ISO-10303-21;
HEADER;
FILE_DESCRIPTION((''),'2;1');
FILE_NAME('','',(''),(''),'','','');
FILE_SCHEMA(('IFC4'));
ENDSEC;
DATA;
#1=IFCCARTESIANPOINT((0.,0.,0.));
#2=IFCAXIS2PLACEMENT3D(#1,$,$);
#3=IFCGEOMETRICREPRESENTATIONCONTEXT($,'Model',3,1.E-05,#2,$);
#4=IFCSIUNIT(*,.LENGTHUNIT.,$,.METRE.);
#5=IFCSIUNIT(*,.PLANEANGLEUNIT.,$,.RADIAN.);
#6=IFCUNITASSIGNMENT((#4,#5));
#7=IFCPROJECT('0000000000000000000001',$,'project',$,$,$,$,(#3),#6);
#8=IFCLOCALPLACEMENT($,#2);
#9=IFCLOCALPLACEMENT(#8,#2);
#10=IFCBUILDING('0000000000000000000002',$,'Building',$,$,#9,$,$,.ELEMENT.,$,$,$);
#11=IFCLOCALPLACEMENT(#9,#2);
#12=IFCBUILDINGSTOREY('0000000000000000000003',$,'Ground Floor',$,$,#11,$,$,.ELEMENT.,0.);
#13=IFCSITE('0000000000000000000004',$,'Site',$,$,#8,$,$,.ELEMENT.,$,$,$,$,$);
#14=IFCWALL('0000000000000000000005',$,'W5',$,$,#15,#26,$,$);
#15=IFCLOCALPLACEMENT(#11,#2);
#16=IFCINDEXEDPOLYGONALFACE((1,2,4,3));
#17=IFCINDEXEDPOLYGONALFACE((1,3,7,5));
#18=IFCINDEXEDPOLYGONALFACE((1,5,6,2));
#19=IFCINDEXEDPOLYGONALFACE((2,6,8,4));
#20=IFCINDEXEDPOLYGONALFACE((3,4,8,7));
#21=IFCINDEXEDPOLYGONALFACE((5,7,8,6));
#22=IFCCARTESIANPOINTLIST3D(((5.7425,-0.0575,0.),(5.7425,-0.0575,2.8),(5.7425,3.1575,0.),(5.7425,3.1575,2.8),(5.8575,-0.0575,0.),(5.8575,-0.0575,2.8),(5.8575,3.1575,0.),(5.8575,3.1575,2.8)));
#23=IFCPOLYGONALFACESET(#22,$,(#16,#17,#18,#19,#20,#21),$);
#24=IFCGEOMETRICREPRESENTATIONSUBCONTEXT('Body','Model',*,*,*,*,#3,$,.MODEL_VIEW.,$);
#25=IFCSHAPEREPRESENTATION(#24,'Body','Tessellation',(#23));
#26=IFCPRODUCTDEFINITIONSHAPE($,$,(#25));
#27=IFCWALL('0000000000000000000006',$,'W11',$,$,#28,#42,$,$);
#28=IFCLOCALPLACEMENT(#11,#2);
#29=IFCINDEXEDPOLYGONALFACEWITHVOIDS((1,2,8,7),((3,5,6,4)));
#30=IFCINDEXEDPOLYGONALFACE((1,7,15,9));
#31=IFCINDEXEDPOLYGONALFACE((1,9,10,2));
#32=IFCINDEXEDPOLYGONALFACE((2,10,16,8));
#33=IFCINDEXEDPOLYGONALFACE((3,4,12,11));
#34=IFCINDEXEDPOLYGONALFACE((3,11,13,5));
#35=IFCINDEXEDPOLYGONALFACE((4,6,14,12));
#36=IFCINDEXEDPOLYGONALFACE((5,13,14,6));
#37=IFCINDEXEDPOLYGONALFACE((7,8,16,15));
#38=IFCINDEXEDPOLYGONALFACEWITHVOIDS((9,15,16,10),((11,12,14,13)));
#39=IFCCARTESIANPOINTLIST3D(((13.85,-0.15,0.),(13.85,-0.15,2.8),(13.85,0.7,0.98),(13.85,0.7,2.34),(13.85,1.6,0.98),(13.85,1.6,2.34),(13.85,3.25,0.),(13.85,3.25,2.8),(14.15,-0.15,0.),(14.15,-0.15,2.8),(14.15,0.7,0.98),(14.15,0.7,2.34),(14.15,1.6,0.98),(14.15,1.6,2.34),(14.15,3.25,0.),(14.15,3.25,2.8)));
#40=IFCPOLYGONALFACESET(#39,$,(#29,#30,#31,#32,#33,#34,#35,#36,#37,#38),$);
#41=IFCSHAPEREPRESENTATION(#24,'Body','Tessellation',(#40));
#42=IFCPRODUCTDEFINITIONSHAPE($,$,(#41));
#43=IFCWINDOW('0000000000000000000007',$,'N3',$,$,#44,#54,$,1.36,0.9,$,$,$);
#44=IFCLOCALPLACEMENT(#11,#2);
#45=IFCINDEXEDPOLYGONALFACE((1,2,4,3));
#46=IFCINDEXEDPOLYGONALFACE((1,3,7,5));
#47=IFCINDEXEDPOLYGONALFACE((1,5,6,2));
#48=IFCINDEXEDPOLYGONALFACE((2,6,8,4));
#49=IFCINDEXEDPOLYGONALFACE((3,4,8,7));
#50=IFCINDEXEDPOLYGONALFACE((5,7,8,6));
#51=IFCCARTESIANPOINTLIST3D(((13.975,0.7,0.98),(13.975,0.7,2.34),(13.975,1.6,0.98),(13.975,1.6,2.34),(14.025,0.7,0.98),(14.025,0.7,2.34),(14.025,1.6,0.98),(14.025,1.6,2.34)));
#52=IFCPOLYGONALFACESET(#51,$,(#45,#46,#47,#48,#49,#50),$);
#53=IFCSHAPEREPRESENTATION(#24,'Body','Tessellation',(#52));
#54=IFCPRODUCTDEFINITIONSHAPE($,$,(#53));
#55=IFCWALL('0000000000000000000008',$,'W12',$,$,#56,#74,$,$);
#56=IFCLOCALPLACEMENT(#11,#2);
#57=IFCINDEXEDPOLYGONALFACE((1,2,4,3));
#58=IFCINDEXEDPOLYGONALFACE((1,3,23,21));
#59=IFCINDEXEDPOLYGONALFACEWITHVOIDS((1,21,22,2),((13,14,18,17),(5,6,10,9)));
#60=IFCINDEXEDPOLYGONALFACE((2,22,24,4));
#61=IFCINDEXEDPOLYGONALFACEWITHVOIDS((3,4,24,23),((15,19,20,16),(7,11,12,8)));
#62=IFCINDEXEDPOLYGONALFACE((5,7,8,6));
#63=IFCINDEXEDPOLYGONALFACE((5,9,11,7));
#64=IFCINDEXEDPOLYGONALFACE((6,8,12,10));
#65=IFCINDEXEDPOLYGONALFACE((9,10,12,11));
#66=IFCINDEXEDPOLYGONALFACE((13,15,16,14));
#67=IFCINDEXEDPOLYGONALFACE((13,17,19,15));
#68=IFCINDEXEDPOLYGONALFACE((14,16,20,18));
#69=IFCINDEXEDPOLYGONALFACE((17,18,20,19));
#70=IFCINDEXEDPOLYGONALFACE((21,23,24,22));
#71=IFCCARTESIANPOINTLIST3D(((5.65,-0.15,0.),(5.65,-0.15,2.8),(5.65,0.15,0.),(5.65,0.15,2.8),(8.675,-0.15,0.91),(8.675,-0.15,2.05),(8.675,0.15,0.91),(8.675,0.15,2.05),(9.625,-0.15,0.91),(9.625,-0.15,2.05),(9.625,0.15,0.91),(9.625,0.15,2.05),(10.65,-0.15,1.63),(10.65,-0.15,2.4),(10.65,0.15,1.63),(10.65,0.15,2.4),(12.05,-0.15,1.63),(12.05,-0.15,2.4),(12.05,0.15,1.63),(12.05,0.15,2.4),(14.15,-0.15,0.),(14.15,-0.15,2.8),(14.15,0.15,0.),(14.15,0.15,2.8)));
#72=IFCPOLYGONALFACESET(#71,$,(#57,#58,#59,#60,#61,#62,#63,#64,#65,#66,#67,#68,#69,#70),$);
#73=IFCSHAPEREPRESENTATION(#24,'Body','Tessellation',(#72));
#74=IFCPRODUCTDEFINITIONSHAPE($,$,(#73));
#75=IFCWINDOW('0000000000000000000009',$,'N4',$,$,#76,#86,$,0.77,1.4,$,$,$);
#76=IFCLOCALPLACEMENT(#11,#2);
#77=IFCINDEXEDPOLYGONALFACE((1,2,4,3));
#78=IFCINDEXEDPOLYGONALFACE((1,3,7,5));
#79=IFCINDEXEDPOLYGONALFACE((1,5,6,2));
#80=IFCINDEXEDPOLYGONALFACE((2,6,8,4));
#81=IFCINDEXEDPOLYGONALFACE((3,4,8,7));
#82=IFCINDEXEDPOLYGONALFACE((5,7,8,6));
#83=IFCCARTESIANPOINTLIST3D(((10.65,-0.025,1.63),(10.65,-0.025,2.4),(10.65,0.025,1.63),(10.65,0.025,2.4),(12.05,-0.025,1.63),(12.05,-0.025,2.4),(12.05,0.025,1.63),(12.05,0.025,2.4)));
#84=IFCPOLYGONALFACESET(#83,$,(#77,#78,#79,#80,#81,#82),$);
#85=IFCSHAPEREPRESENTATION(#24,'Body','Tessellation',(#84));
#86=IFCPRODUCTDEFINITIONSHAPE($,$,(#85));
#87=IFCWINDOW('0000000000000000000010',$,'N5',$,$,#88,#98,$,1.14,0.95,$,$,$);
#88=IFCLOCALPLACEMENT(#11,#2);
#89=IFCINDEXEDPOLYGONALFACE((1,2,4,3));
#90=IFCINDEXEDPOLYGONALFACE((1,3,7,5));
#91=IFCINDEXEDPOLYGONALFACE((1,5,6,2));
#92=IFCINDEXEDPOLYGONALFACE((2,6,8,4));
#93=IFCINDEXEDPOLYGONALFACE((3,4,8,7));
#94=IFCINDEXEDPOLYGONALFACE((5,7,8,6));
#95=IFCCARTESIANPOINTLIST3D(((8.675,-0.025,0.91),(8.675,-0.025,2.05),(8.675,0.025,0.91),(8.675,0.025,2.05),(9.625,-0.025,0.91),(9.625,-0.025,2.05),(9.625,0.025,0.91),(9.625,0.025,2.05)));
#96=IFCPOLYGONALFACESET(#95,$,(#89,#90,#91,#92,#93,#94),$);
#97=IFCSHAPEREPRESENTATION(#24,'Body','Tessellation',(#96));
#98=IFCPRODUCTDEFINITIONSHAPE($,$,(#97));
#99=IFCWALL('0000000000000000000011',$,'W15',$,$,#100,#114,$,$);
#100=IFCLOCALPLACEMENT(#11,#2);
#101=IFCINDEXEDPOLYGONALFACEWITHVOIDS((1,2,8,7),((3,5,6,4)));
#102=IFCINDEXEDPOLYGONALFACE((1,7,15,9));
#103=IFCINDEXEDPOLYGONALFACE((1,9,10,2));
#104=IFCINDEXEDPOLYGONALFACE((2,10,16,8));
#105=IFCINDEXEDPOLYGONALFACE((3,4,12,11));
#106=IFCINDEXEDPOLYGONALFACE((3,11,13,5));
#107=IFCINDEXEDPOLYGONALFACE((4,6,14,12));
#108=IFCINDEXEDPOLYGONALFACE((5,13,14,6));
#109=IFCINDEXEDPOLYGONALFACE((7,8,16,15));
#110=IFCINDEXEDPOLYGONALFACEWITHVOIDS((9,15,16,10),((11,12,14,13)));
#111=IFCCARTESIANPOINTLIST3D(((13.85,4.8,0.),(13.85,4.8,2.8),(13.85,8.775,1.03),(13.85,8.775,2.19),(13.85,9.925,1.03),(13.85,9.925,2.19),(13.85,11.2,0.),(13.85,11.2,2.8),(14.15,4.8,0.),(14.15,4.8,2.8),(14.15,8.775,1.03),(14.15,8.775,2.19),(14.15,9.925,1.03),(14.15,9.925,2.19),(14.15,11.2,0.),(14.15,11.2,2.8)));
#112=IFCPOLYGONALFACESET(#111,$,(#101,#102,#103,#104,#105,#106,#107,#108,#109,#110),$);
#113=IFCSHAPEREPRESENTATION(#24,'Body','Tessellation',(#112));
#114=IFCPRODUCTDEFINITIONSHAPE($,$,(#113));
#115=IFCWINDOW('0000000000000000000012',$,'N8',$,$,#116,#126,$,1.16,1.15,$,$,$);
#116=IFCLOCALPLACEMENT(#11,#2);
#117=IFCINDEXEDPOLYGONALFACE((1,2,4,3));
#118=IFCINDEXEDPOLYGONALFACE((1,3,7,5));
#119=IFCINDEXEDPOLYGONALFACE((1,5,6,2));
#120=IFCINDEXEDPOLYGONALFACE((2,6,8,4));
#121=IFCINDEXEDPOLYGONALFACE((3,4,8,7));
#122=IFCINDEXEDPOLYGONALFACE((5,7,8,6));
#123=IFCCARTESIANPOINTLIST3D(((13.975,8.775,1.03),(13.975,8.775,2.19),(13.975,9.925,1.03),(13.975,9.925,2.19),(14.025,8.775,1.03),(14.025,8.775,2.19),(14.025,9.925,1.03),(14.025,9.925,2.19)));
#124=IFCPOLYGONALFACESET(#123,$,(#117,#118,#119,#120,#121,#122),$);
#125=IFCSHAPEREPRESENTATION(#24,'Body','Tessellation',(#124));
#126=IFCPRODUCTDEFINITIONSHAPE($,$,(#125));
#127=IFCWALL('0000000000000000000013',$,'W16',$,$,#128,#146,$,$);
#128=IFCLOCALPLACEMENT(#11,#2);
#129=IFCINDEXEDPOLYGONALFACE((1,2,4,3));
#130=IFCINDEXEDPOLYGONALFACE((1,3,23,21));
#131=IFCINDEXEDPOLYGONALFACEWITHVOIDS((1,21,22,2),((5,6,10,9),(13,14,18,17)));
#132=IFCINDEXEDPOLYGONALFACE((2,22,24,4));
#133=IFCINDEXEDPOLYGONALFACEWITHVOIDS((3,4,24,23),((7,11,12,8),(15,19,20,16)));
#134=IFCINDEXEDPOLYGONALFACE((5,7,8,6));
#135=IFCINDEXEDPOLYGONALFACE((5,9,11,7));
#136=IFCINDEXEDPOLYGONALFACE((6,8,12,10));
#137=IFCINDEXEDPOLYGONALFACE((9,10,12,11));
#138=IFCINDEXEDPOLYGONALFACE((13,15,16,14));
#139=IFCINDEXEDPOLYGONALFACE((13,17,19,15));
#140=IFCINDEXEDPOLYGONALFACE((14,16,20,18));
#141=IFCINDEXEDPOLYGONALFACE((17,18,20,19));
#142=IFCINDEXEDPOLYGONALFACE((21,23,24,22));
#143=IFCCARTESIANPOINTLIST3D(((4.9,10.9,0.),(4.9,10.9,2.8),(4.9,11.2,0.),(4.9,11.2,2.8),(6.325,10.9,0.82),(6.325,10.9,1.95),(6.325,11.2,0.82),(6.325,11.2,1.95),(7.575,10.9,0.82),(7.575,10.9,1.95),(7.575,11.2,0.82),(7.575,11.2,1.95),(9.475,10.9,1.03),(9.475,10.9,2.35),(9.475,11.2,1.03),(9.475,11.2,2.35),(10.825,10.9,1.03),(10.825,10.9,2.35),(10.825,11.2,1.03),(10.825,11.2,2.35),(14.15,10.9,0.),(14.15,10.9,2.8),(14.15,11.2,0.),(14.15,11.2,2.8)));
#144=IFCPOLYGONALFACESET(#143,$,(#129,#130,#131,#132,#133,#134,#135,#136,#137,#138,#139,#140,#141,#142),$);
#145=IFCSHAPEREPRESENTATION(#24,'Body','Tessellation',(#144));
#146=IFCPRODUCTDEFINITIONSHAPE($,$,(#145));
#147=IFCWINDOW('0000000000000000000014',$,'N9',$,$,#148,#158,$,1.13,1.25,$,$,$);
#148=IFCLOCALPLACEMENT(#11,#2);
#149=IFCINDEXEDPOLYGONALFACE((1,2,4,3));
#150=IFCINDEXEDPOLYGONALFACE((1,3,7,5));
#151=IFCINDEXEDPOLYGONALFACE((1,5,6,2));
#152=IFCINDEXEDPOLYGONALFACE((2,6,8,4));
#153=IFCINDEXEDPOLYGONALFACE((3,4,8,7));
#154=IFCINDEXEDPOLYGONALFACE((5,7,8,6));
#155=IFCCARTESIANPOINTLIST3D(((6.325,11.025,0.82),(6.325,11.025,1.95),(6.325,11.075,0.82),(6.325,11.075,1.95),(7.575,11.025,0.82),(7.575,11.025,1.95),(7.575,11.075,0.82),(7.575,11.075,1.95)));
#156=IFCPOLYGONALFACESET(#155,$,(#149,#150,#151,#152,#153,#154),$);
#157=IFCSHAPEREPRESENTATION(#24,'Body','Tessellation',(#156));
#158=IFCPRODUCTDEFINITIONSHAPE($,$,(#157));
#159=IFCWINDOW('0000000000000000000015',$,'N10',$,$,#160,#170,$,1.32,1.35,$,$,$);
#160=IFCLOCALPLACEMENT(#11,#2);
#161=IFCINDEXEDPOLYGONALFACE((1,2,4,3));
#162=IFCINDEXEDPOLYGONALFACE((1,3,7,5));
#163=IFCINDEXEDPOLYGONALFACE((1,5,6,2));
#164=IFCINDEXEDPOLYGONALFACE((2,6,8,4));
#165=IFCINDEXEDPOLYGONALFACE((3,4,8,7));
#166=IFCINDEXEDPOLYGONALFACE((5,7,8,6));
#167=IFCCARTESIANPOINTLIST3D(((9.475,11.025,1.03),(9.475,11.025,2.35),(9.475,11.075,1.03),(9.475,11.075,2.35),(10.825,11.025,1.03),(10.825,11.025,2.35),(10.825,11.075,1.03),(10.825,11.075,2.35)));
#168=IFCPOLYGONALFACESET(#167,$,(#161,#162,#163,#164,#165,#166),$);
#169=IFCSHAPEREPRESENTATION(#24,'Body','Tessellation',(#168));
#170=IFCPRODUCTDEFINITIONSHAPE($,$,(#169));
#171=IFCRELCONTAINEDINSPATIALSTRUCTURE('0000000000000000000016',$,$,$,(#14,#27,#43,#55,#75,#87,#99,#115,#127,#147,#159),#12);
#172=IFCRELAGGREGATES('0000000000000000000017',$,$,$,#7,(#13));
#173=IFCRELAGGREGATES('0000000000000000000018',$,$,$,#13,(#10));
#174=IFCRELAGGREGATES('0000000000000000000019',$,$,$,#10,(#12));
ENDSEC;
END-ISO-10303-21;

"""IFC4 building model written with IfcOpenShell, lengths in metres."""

from ifc_helpers import new_model, si_unit, frame, frame_2d, origin, origin_2d, place, context, subcontext, project, spatial, rectangle, extrude, element, fill, save


model = new_model("IFC4")

# Units and contexts
model_context = context("Model", 3, precision=1e-05, world=origin())
body_context = subcontext(model_context, "Body", "Model", "MODEL_VIEW")
ifc_project = project(units=[si_unit("LENGTHUNIT", "METRE"), si_unit("PLANEANGLEUNIT", "RADIAN")], contexts=[model_context])

# Site, building, storey
site_placement = place(None, origin())
site = spatial("IfcSite", under=ifc_project, at=site_placement, Name="Site", CompositionType="ELEMENT")
building_placement = place(site_placement, origin())
building = spatial("IfcBuilding", under=site, at=building_placement, Name="Building", CompositionType="ELEMENT")
storey_placement = place(building_placement, origin())
storey = spatial("IfcBuildingStorey", under=building, at=storey_placement, Name="Ground Floor", CompositionType="ELEMENT", Elevation=0.0)

# Wall
wall_1_placement = place(storey_placement, frame((5.8, 0.0, 0.0), x_axis=(0.0, 1.0, 0.0)))
element("IfcWall", 1, at=wall_1_placement, inside=storey, Name="W5", context=body_context, shape_type="SweptSolid", body=[
    extrude(rectangle(XDim=3.215, YDim=0.115, at=frame_2d((1.55, 0.0))), origin(), (0.0, 0.0, 1.0), 2.8),
])

# Wall, opening, window
wall_2_placement = place(storey_placement, frame((14.0, 0.0, 0.0), x_axis=(0.0, 1.0, 0.0)))
wall_2 = element("IfcWall", 2, at=wall_2_placement, inside=storey, Name="W11", context=body_context, shape_type="SweptSolid", body=[
    extrude(rectangle(XDim=3.4, YDim=0.3, at=frame_2d((1.55, 0.0))), origin(), (0.0, 0.0, 1.0), 2.8),
])
opening_1_placement = place(wall_2_placement, frame((1.15, 0.0, 0.98)))
opening_1 = element("IfcOpeningElement", 3, at=opening_1_placement, cuts=wall_2, context=body_context, shape_type="SweptSolid", body=[
    extrude(rectangle(XDim=0.9, YDim=0.4, at=origin_2d()), origin(), (0.0, 0.0, 1.0), 1.36),
])
window_1_placement = place(opening_1_placement, origin())
window_1 = element("IfcWindow", 4, at=window_1_placement, inside=storey, Name="N3", OverallHeight=1.36, OverallWidth=0.9, context=body_context, shape_type="SweptSolid", body=[
    extrude(rectangle(XDim=0.9, YDim=0.05, at=origin_2d()), origin(), (0.0, 0.0, 1.0), 1.36),
])
fill(opening_1, window_1)

# Wall, openings, windows
wall_3_placement = place(storey_placement, frame((5.8, 0.0, 0.0), x_axis=(1.0, 0.0, 0.0)))
wall_3 = element("IfcWall", 5, at=wall_3_placement, inside=storey, Name="W12", context=body_context, shape_type="SweptSolid", body=[
    extrude(rectangle(XDim=8.5, YDim=0.3, at=frame_2d((4.1, 0.0))), origin(), (0.0, 0.0, 1.0), 2.8),
])
opening_2_placement = place(wall_3_placement, frame((5.55, 0.0, 1.63)))
opening_2 = element("IfcOpeningElement", 6, at=opening_2_placement, cuts=wall_3, context=body_context, shape_type="SweptSolid", body=[
    extrude(rectangle(XDim=1.4, YDim=0.4, at=origin_2d()), origin(), (0.0, 0.0, 1.0), 0.77),
])
opening_3_placement = place(wall_3_placement, frame((3.35, 0.0, 0.91)))
opening_3 = element("IfcOpeningElement", 7, at=opening_3_placement, cuts=wall_3, context=body_context, shape_type="SweptSolid", body=[
    extrude(rectangle(XDim=0.95, YDim=0.4, at=origin_2d()), origin(), (0.0, 0.0, 1.0), 1.14),
])
window_2_placement = place(opening_2_placement, origin())
window_2 = element("IfcWindow", 8, at=window_2_placement, inside=storey, Name="N4", OverallHeight=0.77, OverallWidth=1.4, context=body_context, shape_type="SweptSolid", body=[
    extrude(rectangle(XDim=1.4, YDim=0.05, at=origin_2d()), origin(), (0.0, 0.0, 1.0), 0.77),
])
fill(opening_2, window_2)
window_3_placement = place(opening_3_placement, origin())
window_3 = element("IfcWindow", 9, at=window_3_placement, inside=storey, Name="N5", OverallHeight=1.14, OverallWidth=0.95, context=body_context, shape_type="SweptSolid", body=[
    extrude(rectangle(XDim=0.95, YDim=0.05, at=origin_2d()), origin(), (0.0, 0.0, 1.0), 1.14),
])
fill(opening_3, window_3)

# Wall, opening, window
wall_4_placement = place(storey_placement, frame((14.0, 4.95, 0.0), x_axis=(0.0, 1.0, 0.0)))
wall_4 = element("IfcWall", 10, at=wall_4_placement, inside=storey, Name="W15", context=body_context, shape_type="SweptSolid", body=[
    extrude(rectangle(XDim=6.4, YDim=0.3, at=frame_2d((3.05, 0.0))), origin(), (0.0, 0.0, 1.0), 2.8),
])
opening_4_placement = place(wall_4_placement, frame((4.4, 0.0, 1.03)))
opening_4 = element("IfcOpeningElement", 11, at=opening_4_placement, cuts=wall_4, context=body_context, shape_type="SweptSolid", body=[
    extrude(rectangle(XDim=1.15, YDim=0.4, at=origin_2d()), origin(), (0.0, 0.0, 1.0), 1.16),
])
window_4_placement = place(opening_4_placement, origin())
window_4 = element("IfcWindow", 12, at=window_4_placement, inside=storey, Name="N8", OverallHeight=1.16, OverallWidth=1.15, context=body_context, shape_type="SweptSolid", body=[
    extrude(rectangle(XDim=1.15, YDim=0.05, at=origin_2d()), origin(), (0.0, 0.0, 1.0), 1.16),
])
fill(opening_4, window_4)

# Wall, openings, windows
wall_5_placement = place(storey_placement, frame((5.05, 11.05, 0.0), x_axis=(1.0, 0.0, 0.0)))
wall_5 = element("IfcWall", 13, at=wall_5_placement, inside=storey, Name="W16", context=body_context, shape_type="SweptSolid", body=[
    extrude(rectangle(XDim=9.25, YDim=0.3, at=frame_2d((4.475, 0.0))), origin(), (0.0, 0.0, 1.0), 2.8),
])
opening_5_placement = place(wall_5_placement, frame((1.9, 0.0, 0.82)))
opening_5 = element("IfcOpeningElement", 14, at=opening_5_placement, cuts=wall_5, context=body_context, shape_type="SweptSolid", body=[
    extrude(rectangle(XDim=1.25, YDim=0.4, at=origin_2d()), origin(), (0.0, 0.0, 1.0), 1.13),
])
opening_6_placement = place(wall_5_placement, frame((5.1, 0.0, 1.03)))
opening_6 = element("IfcOpeningElement", 15, at=opening_6_placement, cuts=wall_5, context=body_context, shape_type="SweptSolid", body=[
    extrude(rectangle(XDim=1.35, YDim=0.4, at=origin_2d()), origin(), (0.0, 0.0, 1.0), 1.32),
])
window_5_placement = place(opening_5_placement, origin())
window_5 = element("IfcWindow", 16, at=window_5_placement, inside=storey, Name="N9", OverallHeight=1.13, OverallWidth=1.25, context=body_context, shape_type="SweptSolid", body=[
    extrude(rectangle(XDim=1.25, YDim=0.05, at=origin_2d()), origin(), (0.0, 0.0, 1.0), 1.13),
])
fill(opening_5, window_5)
window_6_placement = place(opening_6_placement, origin())
window_6 = element("IfcWindow", 17, at=window_6_placement, inside=storey, Name="N10", OverallHeight=1.32, OverallWidth=1.35, context=body_context, shape_type="SweptSolid", body=[
    extrude(rectangle(XDim=1.35, YDim=0.05, at=origin_2d()), origin(), (0.0, 0.0, 1.0), 1.32),
])
fill(opening_6, window_6)

save(model, "model.ifc")
